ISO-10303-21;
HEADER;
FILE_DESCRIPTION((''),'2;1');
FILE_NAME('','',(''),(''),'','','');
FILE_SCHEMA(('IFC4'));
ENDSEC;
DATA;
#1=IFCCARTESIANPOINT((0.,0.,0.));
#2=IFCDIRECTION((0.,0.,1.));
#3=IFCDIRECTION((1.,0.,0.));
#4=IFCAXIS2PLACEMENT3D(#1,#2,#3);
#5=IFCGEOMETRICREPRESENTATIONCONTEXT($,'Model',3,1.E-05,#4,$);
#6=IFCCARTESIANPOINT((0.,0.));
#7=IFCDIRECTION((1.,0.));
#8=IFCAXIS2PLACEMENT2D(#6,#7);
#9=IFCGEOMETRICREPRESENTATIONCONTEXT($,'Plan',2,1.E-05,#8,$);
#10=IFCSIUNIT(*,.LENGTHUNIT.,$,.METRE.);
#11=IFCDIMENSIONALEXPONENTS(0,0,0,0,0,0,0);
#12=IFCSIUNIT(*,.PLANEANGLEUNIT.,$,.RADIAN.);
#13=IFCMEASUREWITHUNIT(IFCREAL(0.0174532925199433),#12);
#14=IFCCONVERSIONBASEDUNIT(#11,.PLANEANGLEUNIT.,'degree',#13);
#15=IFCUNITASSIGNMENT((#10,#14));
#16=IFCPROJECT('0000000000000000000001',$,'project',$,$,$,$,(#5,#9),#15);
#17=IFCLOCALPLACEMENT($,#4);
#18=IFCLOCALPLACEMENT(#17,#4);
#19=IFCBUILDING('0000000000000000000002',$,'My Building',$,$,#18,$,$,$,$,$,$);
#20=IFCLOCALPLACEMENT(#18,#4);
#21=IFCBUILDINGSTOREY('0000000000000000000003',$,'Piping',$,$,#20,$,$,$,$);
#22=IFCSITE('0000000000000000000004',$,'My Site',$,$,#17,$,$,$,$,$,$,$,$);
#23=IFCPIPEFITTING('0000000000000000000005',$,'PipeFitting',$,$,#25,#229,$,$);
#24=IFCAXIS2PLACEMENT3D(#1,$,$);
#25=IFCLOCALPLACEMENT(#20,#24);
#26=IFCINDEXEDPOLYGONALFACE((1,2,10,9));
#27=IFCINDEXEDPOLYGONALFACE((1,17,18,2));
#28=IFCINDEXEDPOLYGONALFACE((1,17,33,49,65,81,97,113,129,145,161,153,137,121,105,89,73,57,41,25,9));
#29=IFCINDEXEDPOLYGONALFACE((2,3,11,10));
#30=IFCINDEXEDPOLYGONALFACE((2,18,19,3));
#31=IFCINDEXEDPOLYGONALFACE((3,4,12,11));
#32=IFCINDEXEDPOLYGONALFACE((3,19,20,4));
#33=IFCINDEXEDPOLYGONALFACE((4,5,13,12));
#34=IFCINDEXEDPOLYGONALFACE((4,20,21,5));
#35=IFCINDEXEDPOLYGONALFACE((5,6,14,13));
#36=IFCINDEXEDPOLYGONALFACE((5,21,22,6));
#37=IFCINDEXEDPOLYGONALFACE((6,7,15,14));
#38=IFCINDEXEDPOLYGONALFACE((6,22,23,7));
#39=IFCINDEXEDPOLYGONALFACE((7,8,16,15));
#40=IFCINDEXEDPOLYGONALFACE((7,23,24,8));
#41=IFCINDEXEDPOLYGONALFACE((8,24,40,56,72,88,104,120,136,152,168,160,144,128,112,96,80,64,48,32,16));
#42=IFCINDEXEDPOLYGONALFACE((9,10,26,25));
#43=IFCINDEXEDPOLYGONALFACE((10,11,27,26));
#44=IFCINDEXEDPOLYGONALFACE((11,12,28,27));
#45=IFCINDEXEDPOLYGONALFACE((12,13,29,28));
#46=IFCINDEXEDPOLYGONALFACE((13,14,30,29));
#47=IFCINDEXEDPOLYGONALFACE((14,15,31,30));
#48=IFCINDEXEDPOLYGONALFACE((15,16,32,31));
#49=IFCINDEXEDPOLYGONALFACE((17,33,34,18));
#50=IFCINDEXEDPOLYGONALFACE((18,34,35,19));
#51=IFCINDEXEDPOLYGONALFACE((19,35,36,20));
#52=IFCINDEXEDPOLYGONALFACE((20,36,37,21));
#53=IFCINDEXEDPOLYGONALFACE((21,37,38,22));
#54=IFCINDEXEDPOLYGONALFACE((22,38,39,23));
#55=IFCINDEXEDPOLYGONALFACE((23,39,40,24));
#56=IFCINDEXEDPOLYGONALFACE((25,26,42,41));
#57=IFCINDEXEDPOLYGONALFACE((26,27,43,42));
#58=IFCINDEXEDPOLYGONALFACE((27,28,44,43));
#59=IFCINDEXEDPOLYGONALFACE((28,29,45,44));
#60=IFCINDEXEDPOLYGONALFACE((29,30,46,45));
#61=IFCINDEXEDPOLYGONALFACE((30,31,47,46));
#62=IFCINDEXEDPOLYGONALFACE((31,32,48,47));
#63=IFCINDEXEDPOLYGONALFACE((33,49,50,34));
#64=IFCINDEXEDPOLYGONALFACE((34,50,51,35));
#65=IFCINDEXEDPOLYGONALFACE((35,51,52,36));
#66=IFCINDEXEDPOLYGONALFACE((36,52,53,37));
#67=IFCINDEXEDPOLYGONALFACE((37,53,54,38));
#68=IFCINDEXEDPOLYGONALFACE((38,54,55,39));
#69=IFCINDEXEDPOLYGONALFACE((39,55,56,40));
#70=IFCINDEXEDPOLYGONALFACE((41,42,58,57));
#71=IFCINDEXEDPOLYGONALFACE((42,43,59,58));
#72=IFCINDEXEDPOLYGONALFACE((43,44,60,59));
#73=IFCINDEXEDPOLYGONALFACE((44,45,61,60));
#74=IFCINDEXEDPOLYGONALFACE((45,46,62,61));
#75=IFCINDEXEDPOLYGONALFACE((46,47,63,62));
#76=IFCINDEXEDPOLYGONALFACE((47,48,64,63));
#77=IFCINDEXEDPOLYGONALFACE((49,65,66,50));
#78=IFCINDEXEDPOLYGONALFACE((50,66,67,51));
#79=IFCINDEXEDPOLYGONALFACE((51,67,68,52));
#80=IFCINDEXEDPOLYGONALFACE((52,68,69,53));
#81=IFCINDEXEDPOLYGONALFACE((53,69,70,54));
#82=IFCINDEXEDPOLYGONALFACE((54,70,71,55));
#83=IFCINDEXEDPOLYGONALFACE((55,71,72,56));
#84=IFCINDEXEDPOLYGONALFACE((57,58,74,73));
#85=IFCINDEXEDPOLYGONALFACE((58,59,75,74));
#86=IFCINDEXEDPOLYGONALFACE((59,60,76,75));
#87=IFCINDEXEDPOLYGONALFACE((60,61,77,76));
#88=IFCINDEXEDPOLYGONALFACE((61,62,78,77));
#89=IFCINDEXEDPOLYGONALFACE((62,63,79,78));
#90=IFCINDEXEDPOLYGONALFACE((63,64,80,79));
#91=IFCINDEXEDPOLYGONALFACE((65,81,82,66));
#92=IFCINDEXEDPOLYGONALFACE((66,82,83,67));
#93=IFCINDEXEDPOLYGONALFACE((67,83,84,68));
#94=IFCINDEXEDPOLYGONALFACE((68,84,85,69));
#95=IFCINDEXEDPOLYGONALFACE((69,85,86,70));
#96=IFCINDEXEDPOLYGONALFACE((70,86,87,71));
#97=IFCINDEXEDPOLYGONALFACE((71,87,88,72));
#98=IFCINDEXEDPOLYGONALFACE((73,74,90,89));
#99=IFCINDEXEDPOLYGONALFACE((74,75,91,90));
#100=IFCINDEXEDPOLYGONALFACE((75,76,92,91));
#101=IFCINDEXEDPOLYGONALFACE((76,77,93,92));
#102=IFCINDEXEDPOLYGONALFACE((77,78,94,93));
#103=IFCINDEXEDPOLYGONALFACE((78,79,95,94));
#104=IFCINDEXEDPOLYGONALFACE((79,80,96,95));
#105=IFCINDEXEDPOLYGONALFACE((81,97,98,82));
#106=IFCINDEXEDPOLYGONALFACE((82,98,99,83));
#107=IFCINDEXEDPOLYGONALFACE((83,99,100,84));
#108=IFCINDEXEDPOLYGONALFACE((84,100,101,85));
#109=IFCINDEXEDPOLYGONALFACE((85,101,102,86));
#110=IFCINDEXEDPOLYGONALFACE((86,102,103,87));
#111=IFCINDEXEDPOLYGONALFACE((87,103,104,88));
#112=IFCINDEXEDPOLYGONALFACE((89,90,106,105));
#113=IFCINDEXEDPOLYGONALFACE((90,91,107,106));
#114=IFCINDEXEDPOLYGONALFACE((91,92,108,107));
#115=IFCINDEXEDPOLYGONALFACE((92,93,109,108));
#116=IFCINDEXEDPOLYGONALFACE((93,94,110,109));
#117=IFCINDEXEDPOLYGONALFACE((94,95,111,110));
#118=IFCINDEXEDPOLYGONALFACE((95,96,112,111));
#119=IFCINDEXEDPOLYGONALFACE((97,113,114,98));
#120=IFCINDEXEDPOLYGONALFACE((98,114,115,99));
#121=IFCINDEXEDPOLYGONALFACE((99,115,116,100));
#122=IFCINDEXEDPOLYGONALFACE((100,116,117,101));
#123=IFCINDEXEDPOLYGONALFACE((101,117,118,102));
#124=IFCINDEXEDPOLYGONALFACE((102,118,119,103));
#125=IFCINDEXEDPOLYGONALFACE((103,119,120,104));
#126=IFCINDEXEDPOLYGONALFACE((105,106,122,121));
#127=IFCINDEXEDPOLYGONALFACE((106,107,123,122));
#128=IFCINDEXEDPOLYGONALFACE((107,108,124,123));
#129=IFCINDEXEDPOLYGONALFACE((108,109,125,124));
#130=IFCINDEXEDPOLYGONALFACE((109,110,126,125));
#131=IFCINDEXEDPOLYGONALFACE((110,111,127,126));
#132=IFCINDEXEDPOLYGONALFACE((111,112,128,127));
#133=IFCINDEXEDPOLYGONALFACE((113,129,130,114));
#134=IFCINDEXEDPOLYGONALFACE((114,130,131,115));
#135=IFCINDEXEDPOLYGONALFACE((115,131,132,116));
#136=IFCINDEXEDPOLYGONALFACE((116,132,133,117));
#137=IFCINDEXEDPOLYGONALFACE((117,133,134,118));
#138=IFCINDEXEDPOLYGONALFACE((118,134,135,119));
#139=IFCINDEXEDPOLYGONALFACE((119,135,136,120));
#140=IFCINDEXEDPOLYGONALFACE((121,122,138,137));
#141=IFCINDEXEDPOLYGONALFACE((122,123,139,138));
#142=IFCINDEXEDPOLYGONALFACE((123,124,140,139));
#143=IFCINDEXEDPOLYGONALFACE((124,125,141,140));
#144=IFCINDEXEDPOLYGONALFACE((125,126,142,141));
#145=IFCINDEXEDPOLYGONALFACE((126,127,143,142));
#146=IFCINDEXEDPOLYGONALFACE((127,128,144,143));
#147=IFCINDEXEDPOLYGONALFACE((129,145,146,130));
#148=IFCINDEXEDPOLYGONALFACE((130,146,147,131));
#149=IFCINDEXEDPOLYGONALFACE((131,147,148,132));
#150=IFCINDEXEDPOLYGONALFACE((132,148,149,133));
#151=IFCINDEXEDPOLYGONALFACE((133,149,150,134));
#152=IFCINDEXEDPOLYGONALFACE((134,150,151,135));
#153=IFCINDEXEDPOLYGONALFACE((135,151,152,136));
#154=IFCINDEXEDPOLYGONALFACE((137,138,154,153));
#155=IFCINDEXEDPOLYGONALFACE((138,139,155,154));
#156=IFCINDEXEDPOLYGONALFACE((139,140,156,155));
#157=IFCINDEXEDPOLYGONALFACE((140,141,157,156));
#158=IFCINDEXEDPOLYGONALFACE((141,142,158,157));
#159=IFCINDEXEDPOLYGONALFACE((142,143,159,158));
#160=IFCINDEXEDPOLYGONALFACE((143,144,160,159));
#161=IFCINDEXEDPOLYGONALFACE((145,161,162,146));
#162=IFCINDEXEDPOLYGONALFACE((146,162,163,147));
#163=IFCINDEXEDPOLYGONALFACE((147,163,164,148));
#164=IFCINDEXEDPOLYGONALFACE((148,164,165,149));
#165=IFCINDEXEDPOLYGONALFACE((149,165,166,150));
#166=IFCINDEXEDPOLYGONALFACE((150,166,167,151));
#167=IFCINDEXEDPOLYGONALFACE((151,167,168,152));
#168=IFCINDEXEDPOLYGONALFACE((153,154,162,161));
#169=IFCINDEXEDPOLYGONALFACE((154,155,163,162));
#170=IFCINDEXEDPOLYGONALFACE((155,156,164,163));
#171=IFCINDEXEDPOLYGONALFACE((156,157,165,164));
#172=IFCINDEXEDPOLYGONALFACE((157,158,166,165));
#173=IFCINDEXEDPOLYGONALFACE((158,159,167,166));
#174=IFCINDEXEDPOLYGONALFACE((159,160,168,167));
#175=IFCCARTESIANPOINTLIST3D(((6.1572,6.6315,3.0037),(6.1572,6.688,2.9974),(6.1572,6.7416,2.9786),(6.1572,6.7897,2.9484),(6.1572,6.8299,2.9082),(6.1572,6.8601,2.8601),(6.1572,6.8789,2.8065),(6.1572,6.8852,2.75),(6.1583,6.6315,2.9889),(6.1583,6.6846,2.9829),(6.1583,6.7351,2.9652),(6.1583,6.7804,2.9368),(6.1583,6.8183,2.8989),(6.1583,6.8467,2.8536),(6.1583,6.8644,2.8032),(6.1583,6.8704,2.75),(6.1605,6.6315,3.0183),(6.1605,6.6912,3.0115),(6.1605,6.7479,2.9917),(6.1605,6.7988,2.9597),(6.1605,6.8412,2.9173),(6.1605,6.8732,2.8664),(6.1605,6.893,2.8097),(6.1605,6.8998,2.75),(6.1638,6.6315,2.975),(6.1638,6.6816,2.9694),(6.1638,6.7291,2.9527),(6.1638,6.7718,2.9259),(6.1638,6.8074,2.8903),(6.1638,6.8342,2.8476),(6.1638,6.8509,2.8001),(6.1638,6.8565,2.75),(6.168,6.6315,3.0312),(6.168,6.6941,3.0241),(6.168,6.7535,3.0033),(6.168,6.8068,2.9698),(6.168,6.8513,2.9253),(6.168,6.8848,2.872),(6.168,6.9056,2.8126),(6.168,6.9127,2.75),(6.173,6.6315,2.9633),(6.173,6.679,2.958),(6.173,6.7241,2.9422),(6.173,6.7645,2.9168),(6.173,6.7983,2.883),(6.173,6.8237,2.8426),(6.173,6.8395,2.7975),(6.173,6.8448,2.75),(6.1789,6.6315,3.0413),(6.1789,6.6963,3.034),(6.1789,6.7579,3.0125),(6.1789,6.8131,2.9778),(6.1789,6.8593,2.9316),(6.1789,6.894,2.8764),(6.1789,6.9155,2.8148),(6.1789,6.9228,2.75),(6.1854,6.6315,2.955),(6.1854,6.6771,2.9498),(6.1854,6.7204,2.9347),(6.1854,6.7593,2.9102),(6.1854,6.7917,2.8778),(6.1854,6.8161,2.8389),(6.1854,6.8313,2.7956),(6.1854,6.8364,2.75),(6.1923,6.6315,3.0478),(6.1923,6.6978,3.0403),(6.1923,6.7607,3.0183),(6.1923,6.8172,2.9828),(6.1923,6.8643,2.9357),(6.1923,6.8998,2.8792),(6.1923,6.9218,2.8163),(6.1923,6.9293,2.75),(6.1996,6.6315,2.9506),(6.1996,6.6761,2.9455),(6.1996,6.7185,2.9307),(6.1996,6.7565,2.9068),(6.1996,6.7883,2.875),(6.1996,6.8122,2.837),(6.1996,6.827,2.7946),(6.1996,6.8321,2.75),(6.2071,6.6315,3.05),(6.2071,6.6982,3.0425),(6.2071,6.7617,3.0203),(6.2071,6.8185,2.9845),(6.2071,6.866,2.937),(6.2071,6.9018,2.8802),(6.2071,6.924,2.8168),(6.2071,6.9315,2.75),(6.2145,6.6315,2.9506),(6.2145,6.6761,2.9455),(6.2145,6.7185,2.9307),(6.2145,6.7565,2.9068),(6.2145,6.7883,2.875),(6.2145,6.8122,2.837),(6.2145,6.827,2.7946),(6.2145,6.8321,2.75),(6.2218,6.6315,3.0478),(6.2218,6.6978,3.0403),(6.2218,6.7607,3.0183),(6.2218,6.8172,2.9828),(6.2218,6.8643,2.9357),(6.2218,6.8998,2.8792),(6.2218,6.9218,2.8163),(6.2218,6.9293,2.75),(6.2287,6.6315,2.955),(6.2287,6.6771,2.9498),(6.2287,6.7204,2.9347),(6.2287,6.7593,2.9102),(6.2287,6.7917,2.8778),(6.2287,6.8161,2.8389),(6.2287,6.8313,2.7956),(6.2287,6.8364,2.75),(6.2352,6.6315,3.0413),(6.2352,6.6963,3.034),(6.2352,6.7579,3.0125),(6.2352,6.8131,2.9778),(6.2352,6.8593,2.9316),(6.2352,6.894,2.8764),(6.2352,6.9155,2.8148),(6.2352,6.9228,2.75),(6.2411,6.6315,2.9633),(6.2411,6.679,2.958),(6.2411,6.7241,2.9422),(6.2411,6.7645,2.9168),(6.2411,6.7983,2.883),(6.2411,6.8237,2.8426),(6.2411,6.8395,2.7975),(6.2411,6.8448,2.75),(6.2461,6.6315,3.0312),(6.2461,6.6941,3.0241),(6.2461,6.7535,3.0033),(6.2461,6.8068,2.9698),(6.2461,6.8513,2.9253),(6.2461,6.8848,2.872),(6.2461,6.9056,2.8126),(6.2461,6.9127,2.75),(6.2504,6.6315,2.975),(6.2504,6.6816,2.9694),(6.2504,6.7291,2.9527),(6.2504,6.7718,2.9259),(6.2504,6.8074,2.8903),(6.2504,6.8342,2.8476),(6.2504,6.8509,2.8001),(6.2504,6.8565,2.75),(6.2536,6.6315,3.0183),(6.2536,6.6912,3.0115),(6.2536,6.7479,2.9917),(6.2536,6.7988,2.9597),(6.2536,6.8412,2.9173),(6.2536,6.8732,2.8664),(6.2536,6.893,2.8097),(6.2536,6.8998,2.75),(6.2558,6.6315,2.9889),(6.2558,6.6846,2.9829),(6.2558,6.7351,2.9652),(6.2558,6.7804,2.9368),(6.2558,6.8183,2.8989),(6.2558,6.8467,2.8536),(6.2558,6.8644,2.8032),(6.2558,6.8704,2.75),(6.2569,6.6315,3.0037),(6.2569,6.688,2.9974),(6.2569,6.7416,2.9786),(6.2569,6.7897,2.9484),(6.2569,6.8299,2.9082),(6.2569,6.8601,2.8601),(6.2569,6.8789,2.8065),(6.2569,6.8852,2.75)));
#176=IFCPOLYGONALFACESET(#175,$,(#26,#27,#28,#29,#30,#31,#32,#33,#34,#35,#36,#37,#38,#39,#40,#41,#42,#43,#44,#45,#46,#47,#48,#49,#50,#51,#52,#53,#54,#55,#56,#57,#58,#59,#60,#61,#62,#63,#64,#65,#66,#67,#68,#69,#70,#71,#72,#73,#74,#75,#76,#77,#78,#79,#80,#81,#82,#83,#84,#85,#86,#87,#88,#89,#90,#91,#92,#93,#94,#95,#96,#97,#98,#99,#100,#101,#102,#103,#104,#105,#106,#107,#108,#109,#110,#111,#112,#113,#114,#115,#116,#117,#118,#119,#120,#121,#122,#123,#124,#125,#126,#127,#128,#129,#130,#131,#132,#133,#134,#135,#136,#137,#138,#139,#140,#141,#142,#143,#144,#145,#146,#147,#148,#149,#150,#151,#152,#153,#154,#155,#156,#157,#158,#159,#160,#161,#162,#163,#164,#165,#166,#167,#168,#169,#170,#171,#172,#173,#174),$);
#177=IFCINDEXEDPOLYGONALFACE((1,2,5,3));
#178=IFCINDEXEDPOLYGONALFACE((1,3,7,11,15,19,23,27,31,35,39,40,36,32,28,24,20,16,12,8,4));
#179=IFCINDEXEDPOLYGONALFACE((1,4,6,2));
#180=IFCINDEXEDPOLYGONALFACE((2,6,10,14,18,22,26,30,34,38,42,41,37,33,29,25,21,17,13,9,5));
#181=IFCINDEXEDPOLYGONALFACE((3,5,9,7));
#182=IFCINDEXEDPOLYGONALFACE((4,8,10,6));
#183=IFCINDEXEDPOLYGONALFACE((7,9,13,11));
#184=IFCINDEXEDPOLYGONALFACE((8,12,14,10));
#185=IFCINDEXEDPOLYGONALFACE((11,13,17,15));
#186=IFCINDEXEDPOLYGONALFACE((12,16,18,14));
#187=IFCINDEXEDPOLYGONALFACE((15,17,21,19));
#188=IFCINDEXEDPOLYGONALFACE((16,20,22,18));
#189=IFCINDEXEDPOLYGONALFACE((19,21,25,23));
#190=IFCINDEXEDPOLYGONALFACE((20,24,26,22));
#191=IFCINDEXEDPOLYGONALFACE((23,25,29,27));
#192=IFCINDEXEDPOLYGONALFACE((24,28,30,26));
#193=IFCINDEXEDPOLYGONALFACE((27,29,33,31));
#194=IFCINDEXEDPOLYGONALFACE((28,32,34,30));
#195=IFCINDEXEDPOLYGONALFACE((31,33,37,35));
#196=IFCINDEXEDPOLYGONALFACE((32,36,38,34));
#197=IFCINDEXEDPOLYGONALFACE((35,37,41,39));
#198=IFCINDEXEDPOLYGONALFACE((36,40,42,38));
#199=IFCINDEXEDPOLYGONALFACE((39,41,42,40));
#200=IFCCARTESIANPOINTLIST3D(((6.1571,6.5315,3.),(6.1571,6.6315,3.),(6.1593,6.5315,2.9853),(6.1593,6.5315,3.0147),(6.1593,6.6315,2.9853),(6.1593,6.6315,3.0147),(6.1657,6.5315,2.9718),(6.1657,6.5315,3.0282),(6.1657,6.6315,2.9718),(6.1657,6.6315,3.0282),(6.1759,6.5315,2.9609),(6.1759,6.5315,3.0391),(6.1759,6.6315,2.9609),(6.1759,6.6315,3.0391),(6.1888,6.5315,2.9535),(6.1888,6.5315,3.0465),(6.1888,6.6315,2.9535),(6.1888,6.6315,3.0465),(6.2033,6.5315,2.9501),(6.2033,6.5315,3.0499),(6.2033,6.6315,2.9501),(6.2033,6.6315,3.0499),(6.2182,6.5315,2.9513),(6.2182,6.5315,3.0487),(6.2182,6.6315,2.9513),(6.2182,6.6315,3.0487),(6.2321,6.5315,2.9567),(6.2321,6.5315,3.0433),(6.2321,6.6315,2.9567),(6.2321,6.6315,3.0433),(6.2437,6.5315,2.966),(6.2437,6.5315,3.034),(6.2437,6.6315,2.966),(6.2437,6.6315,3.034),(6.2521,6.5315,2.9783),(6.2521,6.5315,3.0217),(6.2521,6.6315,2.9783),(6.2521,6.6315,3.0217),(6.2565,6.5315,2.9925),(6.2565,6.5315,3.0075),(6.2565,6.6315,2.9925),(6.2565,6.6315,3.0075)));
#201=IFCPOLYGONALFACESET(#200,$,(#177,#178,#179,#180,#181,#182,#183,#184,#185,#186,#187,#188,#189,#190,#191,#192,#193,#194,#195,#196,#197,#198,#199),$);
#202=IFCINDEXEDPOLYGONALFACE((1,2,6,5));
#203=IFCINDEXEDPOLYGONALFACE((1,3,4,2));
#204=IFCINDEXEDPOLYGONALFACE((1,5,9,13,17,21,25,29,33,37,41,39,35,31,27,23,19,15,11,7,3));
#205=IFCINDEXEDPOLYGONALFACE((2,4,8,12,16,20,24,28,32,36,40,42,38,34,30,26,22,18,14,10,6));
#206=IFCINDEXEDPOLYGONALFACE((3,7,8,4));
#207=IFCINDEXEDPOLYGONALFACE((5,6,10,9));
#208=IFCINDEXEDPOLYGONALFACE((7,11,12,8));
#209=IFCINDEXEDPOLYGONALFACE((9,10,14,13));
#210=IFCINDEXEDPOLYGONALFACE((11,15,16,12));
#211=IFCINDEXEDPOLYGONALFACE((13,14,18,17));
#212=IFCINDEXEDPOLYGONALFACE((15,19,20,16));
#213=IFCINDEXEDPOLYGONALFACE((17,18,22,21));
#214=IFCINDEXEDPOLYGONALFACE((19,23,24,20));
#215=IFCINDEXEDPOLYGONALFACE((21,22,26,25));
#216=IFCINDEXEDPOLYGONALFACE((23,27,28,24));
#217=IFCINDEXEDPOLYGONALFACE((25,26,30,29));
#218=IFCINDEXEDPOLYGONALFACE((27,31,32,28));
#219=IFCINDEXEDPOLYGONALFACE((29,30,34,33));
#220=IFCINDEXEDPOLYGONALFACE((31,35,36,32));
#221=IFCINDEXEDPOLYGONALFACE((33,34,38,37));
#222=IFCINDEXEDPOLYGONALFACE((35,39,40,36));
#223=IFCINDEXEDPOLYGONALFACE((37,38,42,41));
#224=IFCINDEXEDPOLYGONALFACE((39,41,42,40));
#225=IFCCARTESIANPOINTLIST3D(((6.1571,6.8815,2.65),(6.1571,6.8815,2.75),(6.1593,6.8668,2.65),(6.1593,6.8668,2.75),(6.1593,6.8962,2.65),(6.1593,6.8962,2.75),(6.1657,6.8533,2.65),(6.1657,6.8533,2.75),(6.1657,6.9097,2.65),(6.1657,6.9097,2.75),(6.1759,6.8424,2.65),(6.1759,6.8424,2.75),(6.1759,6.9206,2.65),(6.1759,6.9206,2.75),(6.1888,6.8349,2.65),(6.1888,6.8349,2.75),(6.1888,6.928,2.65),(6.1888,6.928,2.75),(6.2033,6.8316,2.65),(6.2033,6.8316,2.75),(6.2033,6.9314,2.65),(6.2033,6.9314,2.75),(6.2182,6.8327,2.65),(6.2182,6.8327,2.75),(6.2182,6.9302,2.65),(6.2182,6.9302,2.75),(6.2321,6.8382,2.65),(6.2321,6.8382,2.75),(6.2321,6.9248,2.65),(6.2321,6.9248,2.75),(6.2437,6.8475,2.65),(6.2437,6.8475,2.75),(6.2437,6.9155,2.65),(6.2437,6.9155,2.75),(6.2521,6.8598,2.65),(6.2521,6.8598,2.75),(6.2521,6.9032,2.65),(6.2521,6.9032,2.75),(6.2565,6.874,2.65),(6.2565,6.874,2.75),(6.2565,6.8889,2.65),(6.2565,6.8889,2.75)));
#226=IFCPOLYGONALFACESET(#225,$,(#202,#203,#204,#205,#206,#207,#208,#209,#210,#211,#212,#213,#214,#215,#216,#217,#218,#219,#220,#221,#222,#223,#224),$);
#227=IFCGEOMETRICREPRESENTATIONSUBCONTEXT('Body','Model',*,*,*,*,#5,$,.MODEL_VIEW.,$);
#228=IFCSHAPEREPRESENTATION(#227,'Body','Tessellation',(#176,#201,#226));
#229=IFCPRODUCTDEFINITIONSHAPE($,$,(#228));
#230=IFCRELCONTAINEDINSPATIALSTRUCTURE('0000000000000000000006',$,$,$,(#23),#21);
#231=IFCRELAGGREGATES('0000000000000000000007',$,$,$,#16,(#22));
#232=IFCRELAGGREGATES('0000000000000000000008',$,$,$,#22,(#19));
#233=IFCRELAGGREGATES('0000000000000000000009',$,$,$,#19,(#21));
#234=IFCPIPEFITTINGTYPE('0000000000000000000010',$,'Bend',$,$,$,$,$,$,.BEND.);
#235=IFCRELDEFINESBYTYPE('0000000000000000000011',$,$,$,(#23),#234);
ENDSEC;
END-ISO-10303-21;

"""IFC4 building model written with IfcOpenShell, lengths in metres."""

from ifc_helpers import new_model, entity, si_unit, converted_unit, frame, origin_with_axes, origin_2d_with_axis, place, context, subcontext, project, spatial, circle, extrude, source, transform, mapped, type_object, type_shapes, element, save


model = new_model("IFC4")

# Units and contexts
model_context = context("Model", 3, precision=1e-05, world=origin_with_axes())
plan_context = context("Plan", 2, precision=1e-05, world=origin_2d_with_axis())
body_context = subcontext(model_context, "Body", "Model", "MODEL_VIEW")
ifc_project = project(units=[si_unit("LENGTHUNIT", "METRE"), converted_unit("PLANEANGLEUNIT", "degree", entity("IfcReal", 0.0174532925199433), si_unit("PLANEANGLEUNIT", "RADIAN"), dimensions=[0, 0, 0, 0, 0, 0, 0])], contexts=[model_context, plan_context])

# Site, building, storey
site_placement = place(None, origin_with_axes())
site = spatial("IfcSite", under=ifc_project, at=site_placement, Name="My Site")
building_placement = place(site_placement, origin_with_axes())
building = spatial("IfcBuilding", under=site, at=building_placement, Name="My Building")
storey_placement = place(building_placement, origin_with_axes())
storey = spatial("IfcBuildingStorey", under=building, at=storey_placement, Name="Piping")

# Pipe fitting
pipe_fitting_type_1 = type_object("IfcPipeFittingType", Name="Bend", PredefinedType="BEND")
shared_shape = source(origin_with_axes(), body_context, "Body", "SolidModel", [
    entity("IfcSweptDiskSolid", entity("IfcIndexedPolyCurve", entity("IfcCartesianPointList3D", [[0.0, 0.0, -0.1], [0.0, 0.0732, -0.2768], [0.0, 0.25, -0.35]]), [entity("IfcArcIndex", [1, 2, 3])]), 0.05),
    extrude(circle(Radius=0.05), origin_with_axes(), (0.0, 0.0, -1.0), 0.1),
    extrude(circle(Radius=0.05), frame((0.0, 0.25, -0.35), z_axis=(0.0, 1.0, 0.0), x_axis=(1.0, 0.0, 0.0)), (0.0, 0.0, 1.0), 0.1),
])
type_shapes(pipe_fitting_type_1, [shared_shape])
for number, where, z_axis, x_axis, name in (
    (1, (6.2071, 6.5315, 3.0), (0.0, -1.0, 0.0), (-1.0, 0.0, 0.0), "PipeFitting"),
):
    element("IfcPipeFitting", number, at=place(storey_placement, frame(where, z_axis=z_axis, x_axis=x_axis)), inside=storey, type_object=pipe_fitting_type_1, Name=name, context=body_context, shape_type="MappedRepresentation", body=[
        mapped(shared_shape, transform((0.0, 0.0, 0.0), x_axis=(1.0, 0.0, 0.0), y_axis=(0.0, 1.0, 0.0), z_axis=(0.0, 0.0, 1.0), scale=1.0)),
    ])

save(model, "model.ifc")
